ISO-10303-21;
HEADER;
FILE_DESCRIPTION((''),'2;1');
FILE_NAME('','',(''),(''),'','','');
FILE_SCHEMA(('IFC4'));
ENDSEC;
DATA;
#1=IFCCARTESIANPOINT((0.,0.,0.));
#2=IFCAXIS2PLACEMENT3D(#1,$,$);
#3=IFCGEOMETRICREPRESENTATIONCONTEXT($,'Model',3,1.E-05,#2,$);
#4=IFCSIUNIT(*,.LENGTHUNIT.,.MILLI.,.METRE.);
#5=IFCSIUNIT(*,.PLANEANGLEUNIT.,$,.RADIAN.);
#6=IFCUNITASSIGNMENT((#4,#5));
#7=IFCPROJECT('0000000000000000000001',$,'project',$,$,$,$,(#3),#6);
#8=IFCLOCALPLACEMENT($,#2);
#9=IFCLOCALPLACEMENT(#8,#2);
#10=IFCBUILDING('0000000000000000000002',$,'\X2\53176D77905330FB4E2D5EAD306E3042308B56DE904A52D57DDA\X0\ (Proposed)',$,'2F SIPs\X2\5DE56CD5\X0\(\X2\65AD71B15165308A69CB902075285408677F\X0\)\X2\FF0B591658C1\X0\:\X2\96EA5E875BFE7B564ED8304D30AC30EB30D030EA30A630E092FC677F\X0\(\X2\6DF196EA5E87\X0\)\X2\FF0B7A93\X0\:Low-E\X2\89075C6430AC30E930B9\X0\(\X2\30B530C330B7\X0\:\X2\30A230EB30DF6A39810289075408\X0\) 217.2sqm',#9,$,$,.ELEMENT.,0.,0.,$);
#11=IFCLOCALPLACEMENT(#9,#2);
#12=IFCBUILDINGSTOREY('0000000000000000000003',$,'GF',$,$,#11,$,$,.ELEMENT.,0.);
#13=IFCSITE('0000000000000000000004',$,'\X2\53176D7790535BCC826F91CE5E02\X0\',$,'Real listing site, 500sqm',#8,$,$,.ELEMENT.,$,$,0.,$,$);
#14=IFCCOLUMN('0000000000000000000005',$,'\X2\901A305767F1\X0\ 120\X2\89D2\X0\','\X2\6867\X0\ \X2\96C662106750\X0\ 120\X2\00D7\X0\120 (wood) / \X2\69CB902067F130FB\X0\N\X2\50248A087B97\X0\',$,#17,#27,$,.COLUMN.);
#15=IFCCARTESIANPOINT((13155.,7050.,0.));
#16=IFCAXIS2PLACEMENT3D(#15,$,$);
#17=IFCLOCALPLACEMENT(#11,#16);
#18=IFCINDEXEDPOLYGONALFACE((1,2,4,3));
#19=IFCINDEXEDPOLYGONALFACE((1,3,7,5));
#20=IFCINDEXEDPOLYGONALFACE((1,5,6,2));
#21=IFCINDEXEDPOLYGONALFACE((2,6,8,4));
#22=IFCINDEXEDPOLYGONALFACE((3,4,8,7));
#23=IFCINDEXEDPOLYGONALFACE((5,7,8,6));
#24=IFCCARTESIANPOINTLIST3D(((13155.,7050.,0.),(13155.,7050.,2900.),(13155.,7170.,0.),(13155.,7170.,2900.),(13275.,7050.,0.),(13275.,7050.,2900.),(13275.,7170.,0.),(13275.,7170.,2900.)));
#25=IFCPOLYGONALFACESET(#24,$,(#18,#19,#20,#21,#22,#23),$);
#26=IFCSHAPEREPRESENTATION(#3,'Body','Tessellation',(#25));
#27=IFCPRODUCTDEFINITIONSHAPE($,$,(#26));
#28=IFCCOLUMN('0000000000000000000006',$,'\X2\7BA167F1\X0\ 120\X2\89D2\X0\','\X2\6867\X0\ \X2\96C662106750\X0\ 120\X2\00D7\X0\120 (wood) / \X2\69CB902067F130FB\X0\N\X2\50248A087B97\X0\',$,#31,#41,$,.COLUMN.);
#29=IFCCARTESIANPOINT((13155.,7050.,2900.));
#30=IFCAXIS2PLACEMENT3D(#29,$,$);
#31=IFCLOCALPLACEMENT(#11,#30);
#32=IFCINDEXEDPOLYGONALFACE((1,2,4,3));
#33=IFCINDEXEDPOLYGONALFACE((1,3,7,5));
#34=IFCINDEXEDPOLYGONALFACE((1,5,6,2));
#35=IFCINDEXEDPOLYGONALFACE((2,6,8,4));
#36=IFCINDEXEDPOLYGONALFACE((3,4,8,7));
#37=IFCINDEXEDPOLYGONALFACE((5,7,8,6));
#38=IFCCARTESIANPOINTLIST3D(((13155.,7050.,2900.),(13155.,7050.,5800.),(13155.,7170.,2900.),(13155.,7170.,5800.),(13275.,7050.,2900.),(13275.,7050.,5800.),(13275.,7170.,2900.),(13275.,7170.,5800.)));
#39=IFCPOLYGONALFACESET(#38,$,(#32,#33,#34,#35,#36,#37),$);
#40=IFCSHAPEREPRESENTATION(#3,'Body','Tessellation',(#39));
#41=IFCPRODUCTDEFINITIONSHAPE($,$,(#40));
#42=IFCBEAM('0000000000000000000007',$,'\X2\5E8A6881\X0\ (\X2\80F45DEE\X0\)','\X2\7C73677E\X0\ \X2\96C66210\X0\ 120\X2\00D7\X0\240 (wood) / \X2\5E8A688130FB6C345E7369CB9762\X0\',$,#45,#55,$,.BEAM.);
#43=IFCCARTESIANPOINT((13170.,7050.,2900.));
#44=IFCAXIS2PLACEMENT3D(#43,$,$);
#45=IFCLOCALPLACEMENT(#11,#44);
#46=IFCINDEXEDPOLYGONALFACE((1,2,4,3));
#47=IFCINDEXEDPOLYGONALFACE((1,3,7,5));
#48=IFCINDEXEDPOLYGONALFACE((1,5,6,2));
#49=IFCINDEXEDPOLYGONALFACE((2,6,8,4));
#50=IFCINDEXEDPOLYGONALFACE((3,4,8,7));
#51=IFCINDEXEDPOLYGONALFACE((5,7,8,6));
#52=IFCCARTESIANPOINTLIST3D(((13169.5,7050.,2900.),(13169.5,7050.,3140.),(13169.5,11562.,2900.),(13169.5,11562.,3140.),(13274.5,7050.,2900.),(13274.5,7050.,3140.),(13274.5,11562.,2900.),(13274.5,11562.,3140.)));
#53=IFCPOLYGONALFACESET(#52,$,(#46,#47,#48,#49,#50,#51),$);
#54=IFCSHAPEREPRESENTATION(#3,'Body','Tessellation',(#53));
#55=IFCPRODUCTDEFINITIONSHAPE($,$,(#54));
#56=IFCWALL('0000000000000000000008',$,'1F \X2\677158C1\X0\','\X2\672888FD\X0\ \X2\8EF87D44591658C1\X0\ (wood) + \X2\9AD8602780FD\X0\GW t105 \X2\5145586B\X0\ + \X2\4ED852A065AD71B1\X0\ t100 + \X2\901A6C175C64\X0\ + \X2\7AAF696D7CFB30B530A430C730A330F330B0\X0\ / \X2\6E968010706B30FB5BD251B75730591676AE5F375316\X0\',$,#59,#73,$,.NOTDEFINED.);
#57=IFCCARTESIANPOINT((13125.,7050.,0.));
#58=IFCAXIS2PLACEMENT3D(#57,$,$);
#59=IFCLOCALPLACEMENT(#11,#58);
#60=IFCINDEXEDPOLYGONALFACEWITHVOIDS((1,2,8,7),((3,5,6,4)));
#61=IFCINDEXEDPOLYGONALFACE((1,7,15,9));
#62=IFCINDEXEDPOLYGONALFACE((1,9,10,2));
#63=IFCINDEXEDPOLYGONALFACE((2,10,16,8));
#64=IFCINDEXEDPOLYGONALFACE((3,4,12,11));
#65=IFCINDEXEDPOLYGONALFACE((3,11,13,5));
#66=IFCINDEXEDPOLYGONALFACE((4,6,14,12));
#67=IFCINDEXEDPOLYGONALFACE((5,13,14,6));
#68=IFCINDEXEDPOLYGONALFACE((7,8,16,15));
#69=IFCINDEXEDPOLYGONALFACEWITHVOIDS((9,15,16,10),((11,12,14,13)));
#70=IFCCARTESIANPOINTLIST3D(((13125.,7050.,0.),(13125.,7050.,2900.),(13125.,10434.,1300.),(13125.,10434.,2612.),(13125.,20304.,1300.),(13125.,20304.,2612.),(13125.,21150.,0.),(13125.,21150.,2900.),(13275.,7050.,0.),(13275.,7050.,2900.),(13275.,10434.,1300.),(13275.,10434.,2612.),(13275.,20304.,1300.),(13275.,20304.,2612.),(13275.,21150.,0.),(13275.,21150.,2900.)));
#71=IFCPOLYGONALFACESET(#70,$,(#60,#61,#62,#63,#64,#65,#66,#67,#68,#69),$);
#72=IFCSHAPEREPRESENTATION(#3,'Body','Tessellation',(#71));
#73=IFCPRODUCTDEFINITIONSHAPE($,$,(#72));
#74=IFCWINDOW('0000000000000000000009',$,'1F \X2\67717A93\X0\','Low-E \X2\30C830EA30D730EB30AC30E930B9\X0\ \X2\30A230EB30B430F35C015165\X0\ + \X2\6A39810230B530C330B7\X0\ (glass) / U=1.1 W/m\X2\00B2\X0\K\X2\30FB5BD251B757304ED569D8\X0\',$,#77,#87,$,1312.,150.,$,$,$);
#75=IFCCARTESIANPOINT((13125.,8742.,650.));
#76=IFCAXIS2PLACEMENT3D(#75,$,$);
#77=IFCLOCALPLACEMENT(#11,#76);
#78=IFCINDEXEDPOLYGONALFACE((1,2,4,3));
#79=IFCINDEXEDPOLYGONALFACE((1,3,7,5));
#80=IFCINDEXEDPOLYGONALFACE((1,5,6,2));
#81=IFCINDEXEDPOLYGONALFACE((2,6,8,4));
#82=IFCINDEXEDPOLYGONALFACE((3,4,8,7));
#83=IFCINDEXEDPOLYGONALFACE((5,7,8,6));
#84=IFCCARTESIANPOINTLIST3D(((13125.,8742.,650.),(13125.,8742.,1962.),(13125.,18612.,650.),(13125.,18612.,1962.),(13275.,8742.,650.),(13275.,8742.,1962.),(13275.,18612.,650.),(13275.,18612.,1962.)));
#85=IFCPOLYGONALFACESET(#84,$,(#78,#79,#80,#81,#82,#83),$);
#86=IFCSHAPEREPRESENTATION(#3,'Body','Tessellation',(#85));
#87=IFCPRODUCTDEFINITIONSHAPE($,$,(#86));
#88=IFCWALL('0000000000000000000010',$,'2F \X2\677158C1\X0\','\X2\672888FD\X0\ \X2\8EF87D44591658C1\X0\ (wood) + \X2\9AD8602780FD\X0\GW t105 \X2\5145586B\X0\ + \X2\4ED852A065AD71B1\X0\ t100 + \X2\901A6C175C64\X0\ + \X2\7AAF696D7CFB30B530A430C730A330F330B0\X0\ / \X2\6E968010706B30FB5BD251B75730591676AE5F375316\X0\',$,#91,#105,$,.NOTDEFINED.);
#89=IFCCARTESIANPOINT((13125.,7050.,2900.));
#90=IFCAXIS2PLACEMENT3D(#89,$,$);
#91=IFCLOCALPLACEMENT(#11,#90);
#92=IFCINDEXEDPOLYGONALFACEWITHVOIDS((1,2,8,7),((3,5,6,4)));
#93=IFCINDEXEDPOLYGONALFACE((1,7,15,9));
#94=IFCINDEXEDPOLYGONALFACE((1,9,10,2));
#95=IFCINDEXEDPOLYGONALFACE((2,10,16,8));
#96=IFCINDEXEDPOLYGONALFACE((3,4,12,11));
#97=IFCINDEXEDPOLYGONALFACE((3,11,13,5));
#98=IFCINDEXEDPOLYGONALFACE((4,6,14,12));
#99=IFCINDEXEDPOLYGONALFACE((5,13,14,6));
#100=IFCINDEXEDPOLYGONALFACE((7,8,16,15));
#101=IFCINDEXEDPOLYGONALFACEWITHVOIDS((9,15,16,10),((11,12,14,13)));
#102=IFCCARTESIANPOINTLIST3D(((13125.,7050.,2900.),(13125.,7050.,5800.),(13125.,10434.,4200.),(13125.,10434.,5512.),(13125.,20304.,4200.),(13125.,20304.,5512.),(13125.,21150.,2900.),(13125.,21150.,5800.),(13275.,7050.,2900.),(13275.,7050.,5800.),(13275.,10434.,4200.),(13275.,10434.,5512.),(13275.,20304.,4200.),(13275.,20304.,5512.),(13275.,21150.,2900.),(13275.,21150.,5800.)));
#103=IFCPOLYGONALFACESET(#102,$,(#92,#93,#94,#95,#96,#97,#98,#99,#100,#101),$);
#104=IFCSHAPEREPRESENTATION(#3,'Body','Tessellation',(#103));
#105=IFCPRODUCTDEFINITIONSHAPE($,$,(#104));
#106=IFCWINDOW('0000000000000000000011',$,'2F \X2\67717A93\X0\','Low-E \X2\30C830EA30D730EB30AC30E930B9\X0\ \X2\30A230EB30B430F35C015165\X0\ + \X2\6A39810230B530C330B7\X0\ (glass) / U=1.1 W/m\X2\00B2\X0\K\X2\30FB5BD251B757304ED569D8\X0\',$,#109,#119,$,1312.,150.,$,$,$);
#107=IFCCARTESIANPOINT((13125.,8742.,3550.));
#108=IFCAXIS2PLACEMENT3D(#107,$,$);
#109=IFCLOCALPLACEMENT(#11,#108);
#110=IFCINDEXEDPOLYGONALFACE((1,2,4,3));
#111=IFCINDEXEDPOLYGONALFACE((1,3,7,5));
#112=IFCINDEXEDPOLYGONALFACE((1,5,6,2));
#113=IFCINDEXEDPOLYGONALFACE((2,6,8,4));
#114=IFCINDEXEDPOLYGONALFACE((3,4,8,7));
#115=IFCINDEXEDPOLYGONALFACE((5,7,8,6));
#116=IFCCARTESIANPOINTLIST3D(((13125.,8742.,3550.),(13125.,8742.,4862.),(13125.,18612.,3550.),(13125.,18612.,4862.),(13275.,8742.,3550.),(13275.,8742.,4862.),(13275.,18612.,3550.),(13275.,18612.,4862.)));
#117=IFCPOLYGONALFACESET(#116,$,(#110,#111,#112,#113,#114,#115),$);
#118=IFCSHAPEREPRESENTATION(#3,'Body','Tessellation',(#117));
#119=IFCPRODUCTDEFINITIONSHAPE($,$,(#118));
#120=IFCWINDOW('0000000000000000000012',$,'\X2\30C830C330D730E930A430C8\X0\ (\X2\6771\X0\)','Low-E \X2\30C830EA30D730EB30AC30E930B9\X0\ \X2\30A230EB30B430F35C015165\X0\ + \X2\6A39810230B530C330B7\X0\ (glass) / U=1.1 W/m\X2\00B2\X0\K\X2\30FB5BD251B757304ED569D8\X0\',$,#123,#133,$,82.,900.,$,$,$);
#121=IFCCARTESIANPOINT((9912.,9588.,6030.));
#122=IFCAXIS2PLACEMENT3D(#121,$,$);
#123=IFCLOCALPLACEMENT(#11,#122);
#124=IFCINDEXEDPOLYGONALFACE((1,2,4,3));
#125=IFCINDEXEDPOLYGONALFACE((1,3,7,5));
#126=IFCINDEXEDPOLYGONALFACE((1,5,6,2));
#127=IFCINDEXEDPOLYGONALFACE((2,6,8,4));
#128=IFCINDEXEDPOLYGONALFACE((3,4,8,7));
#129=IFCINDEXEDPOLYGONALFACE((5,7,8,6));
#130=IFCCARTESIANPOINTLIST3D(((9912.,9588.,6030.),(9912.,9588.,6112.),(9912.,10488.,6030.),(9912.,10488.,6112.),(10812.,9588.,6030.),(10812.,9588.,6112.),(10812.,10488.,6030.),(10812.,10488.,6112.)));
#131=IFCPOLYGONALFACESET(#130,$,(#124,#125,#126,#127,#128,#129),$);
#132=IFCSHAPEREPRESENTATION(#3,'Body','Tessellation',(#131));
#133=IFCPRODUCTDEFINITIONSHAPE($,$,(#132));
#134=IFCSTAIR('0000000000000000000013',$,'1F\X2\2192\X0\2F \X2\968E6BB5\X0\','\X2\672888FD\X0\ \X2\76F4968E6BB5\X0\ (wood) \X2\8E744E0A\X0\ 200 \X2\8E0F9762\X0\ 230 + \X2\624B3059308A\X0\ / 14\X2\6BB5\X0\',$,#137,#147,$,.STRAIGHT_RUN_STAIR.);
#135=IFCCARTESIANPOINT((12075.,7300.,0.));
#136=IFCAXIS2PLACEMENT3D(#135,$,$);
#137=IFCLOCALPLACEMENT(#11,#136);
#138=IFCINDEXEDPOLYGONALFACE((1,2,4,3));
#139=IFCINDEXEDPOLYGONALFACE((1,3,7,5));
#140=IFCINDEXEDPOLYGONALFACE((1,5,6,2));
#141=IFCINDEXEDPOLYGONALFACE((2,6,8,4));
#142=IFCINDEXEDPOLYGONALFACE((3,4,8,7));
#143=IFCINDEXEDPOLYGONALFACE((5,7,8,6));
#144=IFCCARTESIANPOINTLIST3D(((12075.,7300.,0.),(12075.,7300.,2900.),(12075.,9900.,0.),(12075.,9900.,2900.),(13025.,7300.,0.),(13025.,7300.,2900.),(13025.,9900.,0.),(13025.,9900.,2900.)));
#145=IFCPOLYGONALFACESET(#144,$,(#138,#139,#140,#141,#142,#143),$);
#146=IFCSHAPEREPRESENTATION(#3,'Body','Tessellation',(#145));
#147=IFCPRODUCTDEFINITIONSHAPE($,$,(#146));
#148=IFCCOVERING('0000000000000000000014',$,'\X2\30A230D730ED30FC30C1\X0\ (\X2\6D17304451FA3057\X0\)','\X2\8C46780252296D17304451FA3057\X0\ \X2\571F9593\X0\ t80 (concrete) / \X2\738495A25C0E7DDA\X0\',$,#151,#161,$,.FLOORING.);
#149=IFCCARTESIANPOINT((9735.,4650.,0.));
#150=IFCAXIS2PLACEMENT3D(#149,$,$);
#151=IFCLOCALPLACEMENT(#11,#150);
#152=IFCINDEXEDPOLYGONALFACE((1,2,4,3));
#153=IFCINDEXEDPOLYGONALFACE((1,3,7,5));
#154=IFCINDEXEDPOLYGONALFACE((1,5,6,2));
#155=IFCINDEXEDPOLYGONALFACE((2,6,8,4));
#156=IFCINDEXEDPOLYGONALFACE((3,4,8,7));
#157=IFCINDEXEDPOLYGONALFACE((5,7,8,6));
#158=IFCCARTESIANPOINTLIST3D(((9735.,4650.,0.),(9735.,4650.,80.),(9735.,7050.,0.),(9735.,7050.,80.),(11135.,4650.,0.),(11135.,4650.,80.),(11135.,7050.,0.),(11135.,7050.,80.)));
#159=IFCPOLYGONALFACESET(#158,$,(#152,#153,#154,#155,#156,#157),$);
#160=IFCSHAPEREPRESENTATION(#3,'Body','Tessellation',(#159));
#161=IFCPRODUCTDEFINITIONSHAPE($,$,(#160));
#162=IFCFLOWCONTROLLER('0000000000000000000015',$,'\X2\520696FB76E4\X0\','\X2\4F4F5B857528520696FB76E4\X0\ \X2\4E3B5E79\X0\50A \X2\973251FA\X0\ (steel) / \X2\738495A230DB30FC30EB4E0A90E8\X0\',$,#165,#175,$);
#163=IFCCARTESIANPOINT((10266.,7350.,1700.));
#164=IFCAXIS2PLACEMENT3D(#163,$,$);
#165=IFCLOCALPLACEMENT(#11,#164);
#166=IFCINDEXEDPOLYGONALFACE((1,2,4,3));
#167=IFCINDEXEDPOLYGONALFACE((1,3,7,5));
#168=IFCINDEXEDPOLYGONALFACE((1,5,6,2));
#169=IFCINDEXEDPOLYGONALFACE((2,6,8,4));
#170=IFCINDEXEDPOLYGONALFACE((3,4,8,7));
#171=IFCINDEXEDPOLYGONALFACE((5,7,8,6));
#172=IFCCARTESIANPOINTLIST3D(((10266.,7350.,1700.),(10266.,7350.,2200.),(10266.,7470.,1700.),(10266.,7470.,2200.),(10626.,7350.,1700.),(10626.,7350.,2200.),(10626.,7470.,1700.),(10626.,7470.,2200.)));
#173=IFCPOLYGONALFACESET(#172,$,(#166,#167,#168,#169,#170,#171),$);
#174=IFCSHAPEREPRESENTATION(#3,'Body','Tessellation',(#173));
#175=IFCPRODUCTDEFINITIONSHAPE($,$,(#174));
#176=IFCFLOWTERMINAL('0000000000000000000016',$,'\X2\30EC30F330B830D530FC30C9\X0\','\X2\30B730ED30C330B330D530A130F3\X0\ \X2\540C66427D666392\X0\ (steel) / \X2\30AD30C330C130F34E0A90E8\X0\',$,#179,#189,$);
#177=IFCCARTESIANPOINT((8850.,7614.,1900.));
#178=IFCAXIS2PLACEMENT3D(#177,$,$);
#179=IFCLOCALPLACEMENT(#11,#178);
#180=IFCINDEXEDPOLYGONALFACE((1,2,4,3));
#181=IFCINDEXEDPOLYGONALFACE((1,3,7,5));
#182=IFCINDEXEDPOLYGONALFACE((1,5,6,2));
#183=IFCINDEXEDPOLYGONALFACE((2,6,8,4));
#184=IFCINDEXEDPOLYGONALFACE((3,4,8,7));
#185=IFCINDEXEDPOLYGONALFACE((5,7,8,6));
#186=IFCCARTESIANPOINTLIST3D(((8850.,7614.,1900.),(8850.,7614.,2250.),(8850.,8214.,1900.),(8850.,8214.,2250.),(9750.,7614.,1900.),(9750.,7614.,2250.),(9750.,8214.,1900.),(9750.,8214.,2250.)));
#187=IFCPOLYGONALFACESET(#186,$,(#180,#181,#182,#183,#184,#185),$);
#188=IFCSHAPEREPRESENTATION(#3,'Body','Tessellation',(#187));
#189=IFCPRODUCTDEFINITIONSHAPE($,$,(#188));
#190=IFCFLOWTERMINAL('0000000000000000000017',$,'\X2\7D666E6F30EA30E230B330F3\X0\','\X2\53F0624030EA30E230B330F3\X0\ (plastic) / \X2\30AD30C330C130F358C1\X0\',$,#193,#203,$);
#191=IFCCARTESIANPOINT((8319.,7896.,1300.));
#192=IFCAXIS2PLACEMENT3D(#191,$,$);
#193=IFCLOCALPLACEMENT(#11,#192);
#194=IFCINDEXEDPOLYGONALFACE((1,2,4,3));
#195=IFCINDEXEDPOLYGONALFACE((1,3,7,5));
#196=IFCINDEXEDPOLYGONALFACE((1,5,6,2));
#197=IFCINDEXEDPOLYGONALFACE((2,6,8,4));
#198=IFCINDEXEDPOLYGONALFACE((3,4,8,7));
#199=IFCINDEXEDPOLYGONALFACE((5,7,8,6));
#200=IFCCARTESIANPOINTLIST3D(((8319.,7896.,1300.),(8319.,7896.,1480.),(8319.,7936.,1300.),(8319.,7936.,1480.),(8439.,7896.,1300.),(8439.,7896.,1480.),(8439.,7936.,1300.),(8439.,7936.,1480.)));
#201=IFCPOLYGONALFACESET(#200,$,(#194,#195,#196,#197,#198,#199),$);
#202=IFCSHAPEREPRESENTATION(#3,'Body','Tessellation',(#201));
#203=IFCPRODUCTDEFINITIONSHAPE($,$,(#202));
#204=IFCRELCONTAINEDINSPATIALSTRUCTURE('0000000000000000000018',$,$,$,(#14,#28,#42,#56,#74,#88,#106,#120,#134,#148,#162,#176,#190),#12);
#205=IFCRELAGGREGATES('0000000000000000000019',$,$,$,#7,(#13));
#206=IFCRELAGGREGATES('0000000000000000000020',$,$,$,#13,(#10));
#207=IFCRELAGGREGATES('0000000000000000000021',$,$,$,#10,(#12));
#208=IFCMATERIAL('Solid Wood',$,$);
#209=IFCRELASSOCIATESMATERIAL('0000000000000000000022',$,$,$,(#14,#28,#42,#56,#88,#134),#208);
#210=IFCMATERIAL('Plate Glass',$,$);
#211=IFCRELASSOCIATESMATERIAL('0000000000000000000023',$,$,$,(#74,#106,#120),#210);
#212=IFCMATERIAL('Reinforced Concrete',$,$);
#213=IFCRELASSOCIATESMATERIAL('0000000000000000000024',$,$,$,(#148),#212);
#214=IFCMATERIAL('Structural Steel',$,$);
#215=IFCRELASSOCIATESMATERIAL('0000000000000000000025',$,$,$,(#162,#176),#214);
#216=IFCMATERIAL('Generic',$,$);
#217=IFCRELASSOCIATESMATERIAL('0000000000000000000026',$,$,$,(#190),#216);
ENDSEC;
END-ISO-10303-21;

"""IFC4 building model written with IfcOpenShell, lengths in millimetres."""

from ifc_helpers import new_model, si_unit, frame, frame_2d, origin, place, context, project, spatial, rectangle, extrude, material, element, fill, save


model = new_model("IFC4")

# Units and contexts
model_context = context("Model", 3, precision=1e-05, world=origin())
ifc_project = project(units=[si_unit("LENGTHUNIT", "METRE", prefix="MILLI"), si_unit("PLANEANGLEUNIT", "RADIAN")], contexts=[model_context])

# Site, building, storey
site_placement = place(None, origin())
site = spatial("IfcSite", under=ifc_project, at=site_placement, Name="北海道富良野市", ObjectType="Real listing site, 500sqm", CompositionType="ELEMENT", RefElevation=0.0)
building_placement = place(site_placement, origin())
building = spatial("IfcBuilding", under=site, at=building_placement, Name="北海道・中庭のある回遊動線 (Proposed)", ObjectType="2F SIPs工法(断熱入り構造用合板)＋外壁:雪庇対策付きガルバリウム鋼板(深雪庇)＋窓:Low-E複層ガラス(サッシ:アルミ樹脂複合) 217.2sqm", CompositionType="ELEMENT", ElevationOfRefHeight=0.0, ElevationOfTerrain=0.0)
storey_placement = place(building_placement, origin())
storey = spatial("IfcBuildingStorey", under=building, at=storey_placement, Name="GF", CompositionType="ELEMENT", Elevation=0.0)

# Columns
ifc_material_1 = material(Name="Solid Wood")
column_1_placement = place(storey_placement, frame((13155.0, 7050.0, 0.0)))
element("IfcColumn", 1, at=column_1_placement, inside=storey, material=ifc_material_1, Name="通し柱 120角", Description="桧 集成材 120×120 (wood) / 構造柱・N値計算", PredefinedType="COLUMN", context=model_context, shape_type="SweptSolid", body=[
    extrude(rectangle(XDim=120.0, YDim=120.0, at=frame_2d((60.0, 60.0))), frame((13155.0, 7050.0, 0.0)), (0.0, 0.0, 1.0), 2900.0),
])
column_2_placement = place(storey_placement, frame((13155.0, 7050.0, 2900.0)))
element("IfcColumn", 2, at=column_2_placement, inside=storey, material=ifc_material_1, Name="管柱 120角", Description="桧 集成材 120×120 (wood) / 構造柱・N値計算", PredefinedType="COLUMN", context=model_context, shape_type="SweptSolid", body=[
    extrude(rectangle(XDim=120.0, YDim=120.0, at=frame_2d((60.0, 60.0))), frame((13155.0, 7050.0, 2900.0)), (0.0, 0.0, 1.0), 2900.0),
])

# Beam
beam_1_placement = place(storey_placement, frame((13170.0, 7050.0, 2900.0)))
element("IfcBeam", 3, at=beam_1_placement, inside=storey, material=ifc_material_1, Name="床梁 (胴差)", Description="米松 集成 120×240 (wood) / 床梁・水平構面", PredefinedType="BEAM", context=model_context, shape_type="SweptSolid", body=[
    extrude(rectangle(XDim=105.0, YDim=4512.0, at=frame_2d((52.0, 2256.0))), frame((13170.0, 7050.0, 2900.0)), (0.0, 0.0, 1.0), 240.0),
])

# Wall, opening, window
wall_1_placement = place(storey_placement, frame((13125.0, 7050.0, 0.0)))
wall_1 = element("IfcWall", 4, at=wall_1_placement, inside=storey, material=ifc_material_1, Name="1F 東壁", Description="木製 軸組外壁 (wood) + 高性能GW t105 充填 + 付加断熱 t100 + 通気層 + 窯業系サイディング / 準耐火・寒冷地外皮強化", PredefinedType="NOTDEFINED", context=model_context, shape_type="SweptSolid", body=[
    extrude(rectangle(XDim=150.0, YDim=14100.0, at=frame_2d((75.0, 7050.0))), frame((13125.0, 7050.0, 0.0)), (0.0, 0.0, 1.0), 2900.0),
])
opening_1_placement = place(storey_placement, frame((13125.0, 8742.0, 650.0)))
opening_1 = element("IfcOpeningElement", 5, at=opening_1_placement, cuts=wall_1, PredefinedType="NOTDEFINED", context=model_context, shape_type="SweptSolid", body=[
    extrude(rectangle(XDim=150.0, YDim=9870.0, at=frame_2d((75.0, 4935.0))), frame((13125.0, 8742.0, 650.0)), (0.0, 0.0, 1.0), 1312.0),
])
ifc_material_2 = material(Name="Plate Glass")
window_1_placement = place(storey_placement, frame((13125.0, 8742.0, 650.0)))
window_1 = element("IfcWindow", 6, at=window_1_placement, inside=storey, material=ifc_material_2, Name="1F 東窓", Description="Low-E トリプルガラス アルゴン封入 + 樹脂サッシ (glass) / U=1.1 W/m²K・寒冷地仕様", OverallHeight=1312.0, OverallWidth=150.0, context=model_context, shape_type="SweptSolid", body=[
    extrude(rectangle(XDim=150.0, YDim=9870.0, at=frame_2d((75.0, 4935.0))), frame((13125.0, 8742.0, 650.0)), (0.0, 0.0, 1.0), 1312.0),
])
fill(opening_1, window_1)

# Wall, opening, window
wall_2_placement = place(storey_placement, frame((13125.0, 7050.0, 2900.0)))
wall_2 = element("IfcWall", 7, at=wall_2_placement, inside=storey, material=ifc_material_1, Name="2F 東壁", Description="木製 軸組外壁 (wood) + 高性能GW t105 充填 + 付加断熱 t100 + 通気層 + 窯業系サイディング / 準耐火・寒冷地外皮強化", PredefinedType="NOTDEFINED", context=model_context, shape_type="SweptSolid", body=[
    extrude(rectangle(XDim=150.0, YDim=14100.0, at=frame_2d((75.0, 7050.0))), frame((13125.0, 7050.0, 2900.0)), (0.0, 0.0, 1.0), 2900.0),
])
opening_2_placement = place(storey_placement, frame((13125.0, 8742.0, 3550.0)))
opening_2 = element("IfcOpeningElement", 8, at=opening_2_placement, cuts=wall_2, PredefinedType="NOTDEFINED", context=model_context, shape_type="SweptSolid", body=[
    extrude(rectangle(XDim=150.0, YDim=9870.0, at=frame_2d((75.0, 4935.0))), frame((13125.0, 8742.0, 3550.0)), (0.0, 0.0, 1.0), 1312.0),
])
window_2_placement = place(storey_placement, frame((13125.0, 8742.0, 3550.0)))
window_2 = element("IfcWindow", 9, at=window_2_placement, inside=storey, material=ifc_material_2, Name="2F 東窓", Description="Low-E トリプルガラス アルゴン封入 + 樹脂サッシ (glass) / U=1.1 W/m²K・寒冷地仕様", OverallHeight=1312.0, OverallWidth=150.0, context=model_context, shape_type="SweptSolid", body=[
    extrude(rectangle(XDim=150.0, YDim=9870.0, at=frame_2d((75.0, 4935.0))), frame((13125.0, 8742.0, 3550.0)), (0.0, 0.0, 1.0), 1312.0),
])
fill(opening_2, window_2)

# Window
window_3_placement = place(storey_placement, frame((9912.0, 9588.0, 6030.0)))
element("IfcWindow", 10, at=window_3_placement, inside=storey, material=ifc_material_2, Name="トップライト (東)", Description="Low-E トリプルガラス アルゴン封入 + 樹脂サッシ (glass) / U=1.1 W/m²K・寒冷地仕様", OverallHeight=82.0, OverallWidth=900.0, context=model_context, shape_type="SweptSolid", body=[
    extrude(rectangle(XDim=900.0, YDim=900.0, at=frame_2d((450.0, 450.0))), frame((9912.0, 9588.0, 6030.0)), (0.0, 0.0, 1.0), 82.0),
])

# Stair
stair_placement = place(storey_placement, frame((12075.0, 7300.0, 0.0)))
element("IfcStair", 11, at=stair_placement, inside=storey, material=ifc_material_1, Name="1F→2F 階段", Description="木製 直階段 (wood) 蹴上 200 踏面 230 + 手すり / 14段", PredefinedType="STRAIGHT_RUN_STAIR", context=model_context, shape_type="SweptSolid", body=[
    extrude(rectangle(XDim=950.0, YDim=2600.0, at=frame_2d((475.0, 1300.0))), frame((12075.0, 7300.0, 0.0)), (0.0, 0.0, 1.0), 2900.0),
])

# Covering
ifc_material_3 = material(Name="Reinforced Concrete")
covering_placement = place(storey_placement, frame((9735.0, 4650.0, 0.0)))
element("IfcCovering", 12, at=covering_placement, inside=storey, material=ifc_material_3, Name="アプローチ (洗い出し)", Description="豆砂利洗い出し 土間 t80 (concrete) / 玄関導線", PredefinedType="FLOORING", context=model_context, shape_type="SweptSolid", body=[
    extrude(rectangle(XDim=1400.0, YDim=2400.0, at=frame_2d((700.0, 1200.0))), frame((9735.0, 4650.0, 0.0)), (0.0, 0.0, 1.0), 80.0),
])

# Flow controller
ifc_material_4 = material(Name="Structural Steel")
flow_controller_placement = place(storey_placement, frame((10266.0, 7350.0, 1700.0)))
element("IfcFlowController", 13, at=flow_controller_placement, inside=storey, material=ifc_material_4, Name="分電盤", Description="住宅用分電盤 主幹50A 露出 (steel) / 玄関ホール上部", context=model_context, shape_type="SweptSolid", body=[
    extrude(rectangle(XDim=360.0, YDim=120.0, at=frame_2d((180.0, 60.0))), frame((10266.0, 7350.0, 1700.0)), (0.0, 0.0, 1.0), 500.0),
])

# Flow terminals
flow_terminal_1_placement = place(storey_placement, frame((8850.0, 7614.0, 1900.0)))
element("IfcFlowTerminal", 14, at=flow_terminal_1_placement, inside=storey, material=ifc_material_4, Name="レンジフード", Description="シロッコファン 同時給排 (steel) / キッチン上部", context=model_context, shape_type="SweptSolid", body=[
    extrude(rectangle(XDim=900.0, YDim=600.0, at=frame_2d((450.0, 300.0))), frame((8850.0, 7614.0, 1900.0)), (0.0, 0.0, 1.0), 350.0),
])
ifc_material_5 = material(Name="Generic")
flow_terminal_2_placement = place(storey_placement, frame((8319.0, 7896.0, 1300.0)))
element("IfcFlowTerminal", 15, at=flow_terminal_2_placement, inside=storey, material=ifc_material_5, Name="給湯リモコン", Description="台所リモコン (plastic) / キッチン壁", context=model_context, shape_type="SweptSolid", body=[
    extrude(rectangle(XDim=120.0, YDim=40.0, at=frame_2d((60.0, 20.0))), frame((8319.0, 7896.0, 1300.0)), (0.0, 0.0, 1.0), 180.0),
])

save(model, "model.ifc")
